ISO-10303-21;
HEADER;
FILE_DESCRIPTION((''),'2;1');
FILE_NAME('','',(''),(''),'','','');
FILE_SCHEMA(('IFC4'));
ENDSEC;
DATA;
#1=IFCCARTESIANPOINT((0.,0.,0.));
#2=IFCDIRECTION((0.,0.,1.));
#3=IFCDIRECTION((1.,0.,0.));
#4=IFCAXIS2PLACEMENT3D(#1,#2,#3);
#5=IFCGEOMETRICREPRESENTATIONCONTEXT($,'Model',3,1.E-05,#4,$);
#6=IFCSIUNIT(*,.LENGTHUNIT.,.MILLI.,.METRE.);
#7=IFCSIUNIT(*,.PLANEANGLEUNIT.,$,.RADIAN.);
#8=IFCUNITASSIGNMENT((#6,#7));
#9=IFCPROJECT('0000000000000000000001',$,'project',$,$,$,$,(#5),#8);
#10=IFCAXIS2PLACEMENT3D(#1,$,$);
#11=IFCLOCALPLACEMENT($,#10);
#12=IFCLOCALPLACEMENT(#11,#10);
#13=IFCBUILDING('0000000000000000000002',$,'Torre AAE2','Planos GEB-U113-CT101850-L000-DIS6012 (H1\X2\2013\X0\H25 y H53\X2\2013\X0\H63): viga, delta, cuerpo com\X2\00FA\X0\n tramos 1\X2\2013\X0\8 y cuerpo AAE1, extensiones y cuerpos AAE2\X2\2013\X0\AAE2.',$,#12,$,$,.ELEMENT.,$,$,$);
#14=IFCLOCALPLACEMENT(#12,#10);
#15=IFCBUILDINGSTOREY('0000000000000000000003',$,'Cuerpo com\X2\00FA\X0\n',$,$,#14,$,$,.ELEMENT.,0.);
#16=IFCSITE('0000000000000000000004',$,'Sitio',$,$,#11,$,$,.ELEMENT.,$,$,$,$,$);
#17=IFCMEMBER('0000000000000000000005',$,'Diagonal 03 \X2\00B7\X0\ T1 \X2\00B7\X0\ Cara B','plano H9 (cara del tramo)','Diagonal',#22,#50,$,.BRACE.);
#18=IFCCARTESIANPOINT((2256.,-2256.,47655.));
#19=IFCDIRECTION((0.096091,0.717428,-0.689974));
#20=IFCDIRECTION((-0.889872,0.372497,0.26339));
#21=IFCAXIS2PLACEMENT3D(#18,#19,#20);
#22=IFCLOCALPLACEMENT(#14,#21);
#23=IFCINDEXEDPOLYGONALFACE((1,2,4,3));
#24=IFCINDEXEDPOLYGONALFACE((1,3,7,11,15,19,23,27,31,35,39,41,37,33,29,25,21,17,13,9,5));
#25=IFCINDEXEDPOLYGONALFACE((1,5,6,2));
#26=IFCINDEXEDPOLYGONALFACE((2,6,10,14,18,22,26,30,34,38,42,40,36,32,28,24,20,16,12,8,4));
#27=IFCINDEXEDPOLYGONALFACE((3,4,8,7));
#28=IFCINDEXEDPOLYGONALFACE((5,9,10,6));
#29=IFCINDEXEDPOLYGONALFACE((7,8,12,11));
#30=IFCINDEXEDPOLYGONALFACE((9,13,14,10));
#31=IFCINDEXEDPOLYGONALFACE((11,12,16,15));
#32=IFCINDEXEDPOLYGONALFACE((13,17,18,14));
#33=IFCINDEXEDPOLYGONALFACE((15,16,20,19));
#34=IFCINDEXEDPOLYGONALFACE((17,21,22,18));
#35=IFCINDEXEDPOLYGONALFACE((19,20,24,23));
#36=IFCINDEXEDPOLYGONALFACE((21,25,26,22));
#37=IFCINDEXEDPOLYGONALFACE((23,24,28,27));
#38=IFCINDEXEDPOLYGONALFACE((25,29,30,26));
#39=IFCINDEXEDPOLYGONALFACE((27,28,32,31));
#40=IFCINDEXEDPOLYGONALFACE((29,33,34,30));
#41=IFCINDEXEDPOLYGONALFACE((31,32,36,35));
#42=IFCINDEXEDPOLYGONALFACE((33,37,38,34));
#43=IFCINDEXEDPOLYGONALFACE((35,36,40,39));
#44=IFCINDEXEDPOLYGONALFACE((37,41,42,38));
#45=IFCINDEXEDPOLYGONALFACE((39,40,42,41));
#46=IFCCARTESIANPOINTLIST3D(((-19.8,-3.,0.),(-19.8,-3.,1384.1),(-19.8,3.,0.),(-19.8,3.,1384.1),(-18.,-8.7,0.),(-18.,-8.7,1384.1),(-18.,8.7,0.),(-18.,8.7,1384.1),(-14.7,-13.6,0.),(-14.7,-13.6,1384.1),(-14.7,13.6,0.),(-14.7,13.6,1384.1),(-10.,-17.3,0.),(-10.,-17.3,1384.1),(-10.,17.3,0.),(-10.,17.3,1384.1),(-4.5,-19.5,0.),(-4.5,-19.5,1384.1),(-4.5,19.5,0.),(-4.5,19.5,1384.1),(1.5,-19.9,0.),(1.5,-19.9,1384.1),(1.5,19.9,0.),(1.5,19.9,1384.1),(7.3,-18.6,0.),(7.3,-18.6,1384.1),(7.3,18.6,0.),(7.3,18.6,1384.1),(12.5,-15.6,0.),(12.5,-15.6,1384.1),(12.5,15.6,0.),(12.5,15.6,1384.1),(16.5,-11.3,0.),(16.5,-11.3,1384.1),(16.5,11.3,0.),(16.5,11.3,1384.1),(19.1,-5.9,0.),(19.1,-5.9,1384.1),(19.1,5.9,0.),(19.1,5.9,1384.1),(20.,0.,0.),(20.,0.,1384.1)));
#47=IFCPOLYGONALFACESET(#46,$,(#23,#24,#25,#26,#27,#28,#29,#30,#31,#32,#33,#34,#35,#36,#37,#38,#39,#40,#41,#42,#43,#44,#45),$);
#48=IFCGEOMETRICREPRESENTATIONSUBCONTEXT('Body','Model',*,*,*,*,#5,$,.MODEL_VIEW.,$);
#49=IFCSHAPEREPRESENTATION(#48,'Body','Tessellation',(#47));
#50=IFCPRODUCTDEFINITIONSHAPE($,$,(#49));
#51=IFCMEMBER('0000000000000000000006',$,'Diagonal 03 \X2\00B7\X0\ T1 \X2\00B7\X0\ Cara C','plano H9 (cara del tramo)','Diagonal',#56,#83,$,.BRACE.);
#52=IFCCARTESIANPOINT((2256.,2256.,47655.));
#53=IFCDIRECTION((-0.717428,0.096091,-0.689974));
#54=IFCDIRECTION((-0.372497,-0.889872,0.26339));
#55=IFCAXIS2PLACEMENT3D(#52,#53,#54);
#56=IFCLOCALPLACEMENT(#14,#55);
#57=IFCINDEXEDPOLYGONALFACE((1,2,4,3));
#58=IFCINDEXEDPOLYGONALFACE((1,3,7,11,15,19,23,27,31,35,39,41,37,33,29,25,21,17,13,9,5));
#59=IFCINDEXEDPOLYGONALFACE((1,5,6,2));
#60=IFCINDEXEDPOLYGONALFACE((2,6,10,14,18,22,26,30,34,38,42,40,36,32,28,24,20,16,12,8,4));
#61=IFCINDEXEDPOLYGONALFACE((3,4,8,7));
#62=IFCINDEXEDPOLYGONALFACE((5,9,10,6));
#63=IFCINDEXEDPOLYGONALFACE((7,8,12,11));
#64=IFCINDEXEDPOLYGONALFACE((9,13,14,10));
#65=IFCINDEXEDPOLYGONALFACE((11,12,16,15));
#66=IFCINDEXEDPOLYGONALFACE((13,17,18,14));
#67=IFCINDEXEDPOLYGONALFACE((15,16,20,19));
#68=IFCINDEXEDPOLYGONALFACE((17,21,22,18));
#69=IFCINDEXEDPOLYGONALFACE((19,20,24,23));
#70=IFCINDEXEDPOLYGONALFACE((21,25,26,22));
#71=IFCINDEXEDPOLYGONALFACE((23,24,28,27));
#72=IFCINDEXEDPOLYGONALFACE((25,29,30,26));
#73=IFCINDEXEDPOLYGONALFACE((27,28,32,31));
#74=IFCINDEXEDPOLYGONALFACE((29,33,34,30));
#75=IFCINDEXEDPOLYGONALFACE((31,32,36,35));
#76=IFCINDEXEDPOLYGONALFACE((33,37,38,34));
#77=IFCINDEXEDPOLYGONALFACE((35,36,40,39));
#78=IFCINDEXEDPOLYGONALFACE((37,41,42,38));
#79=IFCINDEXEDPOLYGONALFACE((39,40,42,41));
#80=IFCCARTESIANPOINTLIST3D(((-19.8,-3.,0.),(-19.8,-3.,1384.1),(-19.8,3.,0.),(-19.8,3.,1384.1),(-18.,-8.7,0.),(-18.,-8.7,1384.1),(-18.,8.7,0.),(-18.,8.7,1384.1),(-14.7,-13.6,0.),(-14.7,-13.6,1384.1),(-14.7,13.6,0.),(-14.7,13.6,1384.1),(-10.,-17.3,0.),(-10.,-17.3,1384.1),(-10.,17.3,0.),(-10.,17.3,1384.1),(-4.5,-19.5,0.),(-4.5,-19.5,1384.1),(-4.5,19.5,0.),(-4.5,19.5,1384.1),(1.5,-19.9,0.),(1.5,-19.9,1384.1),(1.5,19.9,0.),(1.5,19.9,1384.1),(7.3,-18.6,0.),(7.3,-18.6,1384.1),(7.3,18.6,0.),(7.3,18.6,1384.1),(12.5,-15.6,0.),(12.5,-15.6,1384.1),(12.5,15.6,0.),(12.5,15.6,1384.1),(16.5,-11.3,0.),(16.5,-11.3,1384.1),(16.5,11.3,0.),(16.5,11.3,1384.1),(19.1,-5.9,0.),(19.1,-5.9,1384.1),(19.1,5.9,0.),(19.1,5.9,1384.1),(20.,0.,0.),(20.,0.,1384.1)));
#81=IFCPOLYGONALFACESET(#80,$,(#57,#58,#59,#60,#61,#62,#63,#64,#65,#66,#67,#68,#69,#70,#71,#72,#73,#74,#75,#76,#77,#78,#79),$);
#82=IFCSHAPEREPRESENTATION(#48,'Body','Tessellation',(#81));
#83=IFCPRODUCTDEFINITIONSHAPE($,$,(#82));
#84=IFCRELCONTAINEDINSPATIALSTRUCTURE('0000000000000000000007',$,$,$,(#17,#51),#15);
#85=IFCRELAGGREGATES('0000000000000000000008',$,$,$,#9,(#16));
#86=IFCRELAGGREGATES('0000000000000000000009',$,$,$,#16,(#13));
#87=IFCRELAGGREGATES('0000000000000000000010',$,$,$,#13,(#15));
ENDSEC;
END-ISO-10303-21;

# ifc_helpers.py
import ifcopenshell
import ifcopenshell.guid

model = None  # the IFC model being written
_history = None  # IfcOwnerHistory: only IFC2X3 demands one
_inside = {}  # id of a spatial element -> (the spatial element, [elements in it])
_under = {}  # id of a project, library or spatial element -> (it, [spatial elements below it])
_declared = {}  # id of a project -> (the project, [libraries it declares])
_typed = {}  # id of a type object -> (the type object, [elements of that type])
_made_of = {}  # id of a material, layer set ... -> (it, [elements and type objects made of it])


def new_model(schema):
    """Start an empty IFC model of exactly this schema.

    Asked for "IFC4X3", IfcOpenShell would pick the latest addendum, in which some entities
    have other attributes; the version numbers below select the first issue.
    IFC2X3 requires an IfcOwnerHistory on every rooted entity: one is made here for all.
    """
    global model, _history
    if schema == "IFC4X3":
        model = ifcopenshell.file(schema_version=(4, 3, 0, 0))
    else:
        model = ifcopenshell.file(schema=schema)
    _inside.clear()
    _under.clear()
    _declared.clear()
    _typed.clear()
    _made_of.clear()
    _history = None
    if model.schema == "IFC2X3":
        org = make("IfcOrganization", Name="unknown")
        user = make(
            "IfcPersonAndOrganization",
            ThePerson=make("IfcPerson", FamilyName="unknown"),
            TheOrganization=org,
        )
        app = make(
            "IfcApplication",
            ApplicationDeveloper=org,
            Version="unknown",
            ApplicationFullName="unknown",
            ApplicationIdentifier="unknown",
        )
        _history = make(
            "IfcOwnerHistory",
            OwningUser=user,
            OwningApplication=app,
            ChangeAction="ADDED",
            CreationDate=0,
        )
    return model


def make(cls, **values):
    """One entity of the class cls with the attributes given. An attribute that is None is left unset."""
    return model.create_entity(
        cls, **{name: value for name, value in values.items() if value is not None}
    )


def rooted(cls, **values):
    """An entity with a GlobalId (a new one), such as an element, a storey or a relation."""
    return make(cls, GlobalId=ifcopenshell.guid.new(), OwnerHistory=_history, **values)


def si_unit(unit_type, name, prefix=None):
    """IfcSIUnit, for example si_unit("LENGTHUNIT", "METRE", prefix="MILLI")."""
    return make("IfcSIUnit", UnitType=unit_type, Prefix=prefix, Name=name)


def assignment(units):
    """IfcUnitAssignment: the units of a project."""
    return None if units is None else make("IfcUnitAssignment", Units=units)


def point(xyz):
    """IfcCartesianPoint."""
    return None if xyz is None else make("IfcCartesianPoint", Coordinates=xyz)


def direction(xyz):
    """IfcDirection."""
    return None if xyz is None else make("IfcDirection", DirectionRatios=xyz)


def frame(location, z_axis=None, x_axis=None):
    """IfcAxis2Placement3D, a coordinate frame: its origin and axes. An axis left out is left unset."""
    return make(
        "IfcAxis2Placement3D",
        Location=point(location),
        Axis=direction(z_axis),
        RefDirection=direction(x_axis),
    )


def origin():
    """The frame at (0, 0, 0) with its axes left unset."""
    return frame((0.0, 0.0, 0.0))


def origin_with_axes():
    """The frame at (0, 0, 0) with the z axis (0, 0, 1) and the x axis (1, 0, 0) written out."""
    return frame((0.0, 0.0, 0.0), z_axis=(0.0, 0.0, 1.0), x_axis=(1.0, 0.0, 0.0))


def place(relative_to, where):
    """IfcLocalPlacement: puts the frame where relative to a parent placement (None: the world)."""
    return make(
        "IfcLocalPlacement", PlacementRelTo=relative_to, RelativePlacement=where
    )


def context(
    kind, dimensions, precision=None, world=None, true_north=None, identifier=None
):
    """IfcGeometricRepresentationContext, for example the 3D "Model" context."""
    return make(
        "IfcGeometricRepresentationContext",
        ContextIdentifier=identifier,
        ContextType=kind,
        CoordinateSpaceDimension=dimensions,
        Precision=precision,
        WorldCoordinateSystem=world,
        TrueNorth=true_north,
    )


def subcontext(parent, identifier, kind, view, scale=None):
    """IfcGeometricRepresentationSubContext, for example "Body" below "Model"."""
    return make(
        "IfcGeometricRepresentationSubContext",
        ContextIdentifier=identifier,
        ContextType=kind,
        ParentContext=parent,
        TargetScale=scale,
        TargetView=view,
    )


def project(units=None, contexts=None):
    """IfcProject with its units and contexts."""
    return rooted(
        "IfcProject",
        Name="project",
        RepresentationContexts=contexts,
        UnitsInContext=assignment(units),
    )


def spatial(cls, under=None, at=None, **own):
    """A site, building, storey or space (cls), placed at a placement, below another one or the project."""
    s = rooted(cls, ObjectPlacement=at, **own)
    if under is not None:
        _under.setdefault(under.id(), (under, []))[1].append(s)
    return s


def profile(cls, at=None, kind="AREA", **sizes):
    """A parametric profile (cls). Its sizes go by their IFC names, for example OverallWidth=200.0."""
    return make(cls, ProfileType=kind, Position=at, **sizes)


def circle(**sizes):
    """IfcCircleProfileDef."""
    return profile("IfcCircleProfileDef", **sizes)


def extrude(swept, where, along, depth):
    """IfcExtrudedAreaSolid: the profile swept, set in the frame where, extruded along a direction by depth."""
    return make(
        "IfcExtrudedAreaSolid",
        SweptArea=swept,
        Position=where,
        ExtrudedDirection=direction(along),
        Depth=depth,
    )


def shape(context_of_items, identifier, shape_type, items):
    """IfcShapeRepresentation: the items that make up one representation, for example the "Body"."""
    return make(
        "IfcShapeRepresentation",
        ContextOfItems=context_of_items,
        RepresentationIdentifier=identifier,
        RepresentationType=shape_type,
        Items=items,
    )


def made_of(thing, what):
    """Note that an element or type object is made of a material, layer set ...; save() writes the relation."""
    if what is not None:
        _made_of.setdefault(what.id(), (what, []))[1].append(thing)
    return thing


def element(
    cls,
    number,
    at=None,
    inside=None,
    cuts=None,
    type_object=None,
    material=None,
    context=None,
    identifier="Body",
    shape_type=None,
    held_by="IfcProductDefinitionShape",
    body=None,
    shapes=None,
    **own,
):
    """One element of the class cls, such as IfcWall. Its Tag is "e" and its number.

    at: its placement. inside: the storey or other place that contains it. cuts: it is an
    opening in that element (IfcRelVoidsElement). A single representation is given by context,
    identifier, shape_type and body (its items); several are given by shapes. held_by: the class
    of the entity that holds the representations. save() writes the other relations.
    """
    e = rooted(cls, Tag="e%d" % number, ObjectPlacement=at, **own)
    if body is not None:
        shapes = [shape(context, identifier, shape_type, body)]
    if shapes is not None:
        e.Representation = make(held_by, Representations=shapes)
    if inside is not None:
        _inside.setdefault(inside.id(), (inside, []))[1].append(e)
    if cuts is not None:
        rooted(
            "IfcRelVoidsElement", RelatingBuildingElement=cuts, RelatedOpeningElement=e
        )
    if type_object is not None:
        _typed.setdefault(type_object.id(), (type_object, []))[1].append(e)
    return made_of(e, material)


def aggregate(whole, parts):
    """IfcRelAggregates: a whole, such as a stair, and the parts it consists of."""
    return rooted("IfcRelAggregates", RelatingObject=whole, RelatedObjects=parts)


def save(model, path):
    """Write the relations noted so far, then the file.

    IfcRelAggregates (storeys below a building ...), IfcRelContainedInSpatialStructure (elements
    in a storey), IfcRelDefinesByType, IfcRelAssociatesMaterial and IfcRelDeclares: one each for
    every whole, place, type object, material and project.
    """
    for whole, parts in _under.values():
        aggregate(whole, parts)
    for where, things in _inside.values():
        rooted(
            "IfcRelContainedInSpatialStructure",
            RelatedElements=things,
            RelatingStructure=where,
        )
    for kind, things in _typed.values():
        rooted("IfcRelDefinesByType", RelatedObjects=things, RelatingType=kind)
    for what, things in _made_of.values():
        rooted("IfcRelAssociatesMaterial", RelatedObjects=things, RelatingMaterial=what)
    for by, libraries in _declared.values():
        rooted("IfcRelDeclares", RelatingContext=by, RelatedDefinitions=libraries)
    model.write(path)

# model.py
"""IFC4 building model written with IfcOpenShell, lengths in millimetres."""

from ifc_helpers import new_model, si_unit, frame, origin, origin_with_axes, place, context, subcontext, project, spatial, circle, extrude, element, save


model = new_model("IFC4")

# Units and contexts
model_context = context("Model", 3, precision=1e-05, world=origin_with_axes())
body_context = subcontext(model_context, "Body", "Model", "MODEL_VIEW")
ifc_project = project(units=[si_unit("LENGTHUNIT", "METRE", prefix="MILLI"), si_unit("PLANEANGLEUNIT", "RADIAN")], contexts=[model_context])

# Site, building, storey
site_placement = place(None, origin())
site = spatial("IfcSite", under=ifc_project, at=site_placement, Name="Sitio", CompositionType="ELEMENT")
building_placement = place(site_placement, origin())
building = spatial("IfcBuilding", under=site, at=building_placement, Name="Torre AAE2", Description="Planos GEB-U113-CT101850-L000-DIS6012 (H1–H25 y H53–H63): viga, delta, cuerpo común tramos 1–8 y cuerpo AAE1, extensiones y cuerpos AAE2–AAE2.", CompositionType="ELEMENT")
storey_placement = place(building_placement, origin())
storey = spatial("IfcBuildingStorey", under=building, at=storey_placement, Name="Cuerpo común", CompositionType="ELEMENT", Elevation=0.0)

# Members
for number, where, z_axis, x_axis, name in (
    (1, (2256.0, -2256.0, 47655.0), (0.096091, 0.717428, -0.689974), (-0.889872, 0.372497, 0.26339), "Diagonal 03 · T1 · Cara B"),
    (2, (2256.0, 2256.0, 47655.0), (-0.717428, 0.096091, -0.689974), (-0.372497, -0.889872, 0.26339), "Diagonal 03 · T1 · Cara C"),
):
    element("IfcMember", number, at=place(storey_placement, frame(where, z_axis=z_axis, x_axis=x_axis)), inside=storey, Name=name, Description="plano H9 (cara del tramo)", ObjectType="Diagonal", PredefinedType="BRACE", context=body_context, shape_type="SweptSolid", body=[
        extrude(circle(Radius=20.0), None, (0.0, 0.0, 1.0), 1384.1),
    ])

save(model, "model.ifc")
